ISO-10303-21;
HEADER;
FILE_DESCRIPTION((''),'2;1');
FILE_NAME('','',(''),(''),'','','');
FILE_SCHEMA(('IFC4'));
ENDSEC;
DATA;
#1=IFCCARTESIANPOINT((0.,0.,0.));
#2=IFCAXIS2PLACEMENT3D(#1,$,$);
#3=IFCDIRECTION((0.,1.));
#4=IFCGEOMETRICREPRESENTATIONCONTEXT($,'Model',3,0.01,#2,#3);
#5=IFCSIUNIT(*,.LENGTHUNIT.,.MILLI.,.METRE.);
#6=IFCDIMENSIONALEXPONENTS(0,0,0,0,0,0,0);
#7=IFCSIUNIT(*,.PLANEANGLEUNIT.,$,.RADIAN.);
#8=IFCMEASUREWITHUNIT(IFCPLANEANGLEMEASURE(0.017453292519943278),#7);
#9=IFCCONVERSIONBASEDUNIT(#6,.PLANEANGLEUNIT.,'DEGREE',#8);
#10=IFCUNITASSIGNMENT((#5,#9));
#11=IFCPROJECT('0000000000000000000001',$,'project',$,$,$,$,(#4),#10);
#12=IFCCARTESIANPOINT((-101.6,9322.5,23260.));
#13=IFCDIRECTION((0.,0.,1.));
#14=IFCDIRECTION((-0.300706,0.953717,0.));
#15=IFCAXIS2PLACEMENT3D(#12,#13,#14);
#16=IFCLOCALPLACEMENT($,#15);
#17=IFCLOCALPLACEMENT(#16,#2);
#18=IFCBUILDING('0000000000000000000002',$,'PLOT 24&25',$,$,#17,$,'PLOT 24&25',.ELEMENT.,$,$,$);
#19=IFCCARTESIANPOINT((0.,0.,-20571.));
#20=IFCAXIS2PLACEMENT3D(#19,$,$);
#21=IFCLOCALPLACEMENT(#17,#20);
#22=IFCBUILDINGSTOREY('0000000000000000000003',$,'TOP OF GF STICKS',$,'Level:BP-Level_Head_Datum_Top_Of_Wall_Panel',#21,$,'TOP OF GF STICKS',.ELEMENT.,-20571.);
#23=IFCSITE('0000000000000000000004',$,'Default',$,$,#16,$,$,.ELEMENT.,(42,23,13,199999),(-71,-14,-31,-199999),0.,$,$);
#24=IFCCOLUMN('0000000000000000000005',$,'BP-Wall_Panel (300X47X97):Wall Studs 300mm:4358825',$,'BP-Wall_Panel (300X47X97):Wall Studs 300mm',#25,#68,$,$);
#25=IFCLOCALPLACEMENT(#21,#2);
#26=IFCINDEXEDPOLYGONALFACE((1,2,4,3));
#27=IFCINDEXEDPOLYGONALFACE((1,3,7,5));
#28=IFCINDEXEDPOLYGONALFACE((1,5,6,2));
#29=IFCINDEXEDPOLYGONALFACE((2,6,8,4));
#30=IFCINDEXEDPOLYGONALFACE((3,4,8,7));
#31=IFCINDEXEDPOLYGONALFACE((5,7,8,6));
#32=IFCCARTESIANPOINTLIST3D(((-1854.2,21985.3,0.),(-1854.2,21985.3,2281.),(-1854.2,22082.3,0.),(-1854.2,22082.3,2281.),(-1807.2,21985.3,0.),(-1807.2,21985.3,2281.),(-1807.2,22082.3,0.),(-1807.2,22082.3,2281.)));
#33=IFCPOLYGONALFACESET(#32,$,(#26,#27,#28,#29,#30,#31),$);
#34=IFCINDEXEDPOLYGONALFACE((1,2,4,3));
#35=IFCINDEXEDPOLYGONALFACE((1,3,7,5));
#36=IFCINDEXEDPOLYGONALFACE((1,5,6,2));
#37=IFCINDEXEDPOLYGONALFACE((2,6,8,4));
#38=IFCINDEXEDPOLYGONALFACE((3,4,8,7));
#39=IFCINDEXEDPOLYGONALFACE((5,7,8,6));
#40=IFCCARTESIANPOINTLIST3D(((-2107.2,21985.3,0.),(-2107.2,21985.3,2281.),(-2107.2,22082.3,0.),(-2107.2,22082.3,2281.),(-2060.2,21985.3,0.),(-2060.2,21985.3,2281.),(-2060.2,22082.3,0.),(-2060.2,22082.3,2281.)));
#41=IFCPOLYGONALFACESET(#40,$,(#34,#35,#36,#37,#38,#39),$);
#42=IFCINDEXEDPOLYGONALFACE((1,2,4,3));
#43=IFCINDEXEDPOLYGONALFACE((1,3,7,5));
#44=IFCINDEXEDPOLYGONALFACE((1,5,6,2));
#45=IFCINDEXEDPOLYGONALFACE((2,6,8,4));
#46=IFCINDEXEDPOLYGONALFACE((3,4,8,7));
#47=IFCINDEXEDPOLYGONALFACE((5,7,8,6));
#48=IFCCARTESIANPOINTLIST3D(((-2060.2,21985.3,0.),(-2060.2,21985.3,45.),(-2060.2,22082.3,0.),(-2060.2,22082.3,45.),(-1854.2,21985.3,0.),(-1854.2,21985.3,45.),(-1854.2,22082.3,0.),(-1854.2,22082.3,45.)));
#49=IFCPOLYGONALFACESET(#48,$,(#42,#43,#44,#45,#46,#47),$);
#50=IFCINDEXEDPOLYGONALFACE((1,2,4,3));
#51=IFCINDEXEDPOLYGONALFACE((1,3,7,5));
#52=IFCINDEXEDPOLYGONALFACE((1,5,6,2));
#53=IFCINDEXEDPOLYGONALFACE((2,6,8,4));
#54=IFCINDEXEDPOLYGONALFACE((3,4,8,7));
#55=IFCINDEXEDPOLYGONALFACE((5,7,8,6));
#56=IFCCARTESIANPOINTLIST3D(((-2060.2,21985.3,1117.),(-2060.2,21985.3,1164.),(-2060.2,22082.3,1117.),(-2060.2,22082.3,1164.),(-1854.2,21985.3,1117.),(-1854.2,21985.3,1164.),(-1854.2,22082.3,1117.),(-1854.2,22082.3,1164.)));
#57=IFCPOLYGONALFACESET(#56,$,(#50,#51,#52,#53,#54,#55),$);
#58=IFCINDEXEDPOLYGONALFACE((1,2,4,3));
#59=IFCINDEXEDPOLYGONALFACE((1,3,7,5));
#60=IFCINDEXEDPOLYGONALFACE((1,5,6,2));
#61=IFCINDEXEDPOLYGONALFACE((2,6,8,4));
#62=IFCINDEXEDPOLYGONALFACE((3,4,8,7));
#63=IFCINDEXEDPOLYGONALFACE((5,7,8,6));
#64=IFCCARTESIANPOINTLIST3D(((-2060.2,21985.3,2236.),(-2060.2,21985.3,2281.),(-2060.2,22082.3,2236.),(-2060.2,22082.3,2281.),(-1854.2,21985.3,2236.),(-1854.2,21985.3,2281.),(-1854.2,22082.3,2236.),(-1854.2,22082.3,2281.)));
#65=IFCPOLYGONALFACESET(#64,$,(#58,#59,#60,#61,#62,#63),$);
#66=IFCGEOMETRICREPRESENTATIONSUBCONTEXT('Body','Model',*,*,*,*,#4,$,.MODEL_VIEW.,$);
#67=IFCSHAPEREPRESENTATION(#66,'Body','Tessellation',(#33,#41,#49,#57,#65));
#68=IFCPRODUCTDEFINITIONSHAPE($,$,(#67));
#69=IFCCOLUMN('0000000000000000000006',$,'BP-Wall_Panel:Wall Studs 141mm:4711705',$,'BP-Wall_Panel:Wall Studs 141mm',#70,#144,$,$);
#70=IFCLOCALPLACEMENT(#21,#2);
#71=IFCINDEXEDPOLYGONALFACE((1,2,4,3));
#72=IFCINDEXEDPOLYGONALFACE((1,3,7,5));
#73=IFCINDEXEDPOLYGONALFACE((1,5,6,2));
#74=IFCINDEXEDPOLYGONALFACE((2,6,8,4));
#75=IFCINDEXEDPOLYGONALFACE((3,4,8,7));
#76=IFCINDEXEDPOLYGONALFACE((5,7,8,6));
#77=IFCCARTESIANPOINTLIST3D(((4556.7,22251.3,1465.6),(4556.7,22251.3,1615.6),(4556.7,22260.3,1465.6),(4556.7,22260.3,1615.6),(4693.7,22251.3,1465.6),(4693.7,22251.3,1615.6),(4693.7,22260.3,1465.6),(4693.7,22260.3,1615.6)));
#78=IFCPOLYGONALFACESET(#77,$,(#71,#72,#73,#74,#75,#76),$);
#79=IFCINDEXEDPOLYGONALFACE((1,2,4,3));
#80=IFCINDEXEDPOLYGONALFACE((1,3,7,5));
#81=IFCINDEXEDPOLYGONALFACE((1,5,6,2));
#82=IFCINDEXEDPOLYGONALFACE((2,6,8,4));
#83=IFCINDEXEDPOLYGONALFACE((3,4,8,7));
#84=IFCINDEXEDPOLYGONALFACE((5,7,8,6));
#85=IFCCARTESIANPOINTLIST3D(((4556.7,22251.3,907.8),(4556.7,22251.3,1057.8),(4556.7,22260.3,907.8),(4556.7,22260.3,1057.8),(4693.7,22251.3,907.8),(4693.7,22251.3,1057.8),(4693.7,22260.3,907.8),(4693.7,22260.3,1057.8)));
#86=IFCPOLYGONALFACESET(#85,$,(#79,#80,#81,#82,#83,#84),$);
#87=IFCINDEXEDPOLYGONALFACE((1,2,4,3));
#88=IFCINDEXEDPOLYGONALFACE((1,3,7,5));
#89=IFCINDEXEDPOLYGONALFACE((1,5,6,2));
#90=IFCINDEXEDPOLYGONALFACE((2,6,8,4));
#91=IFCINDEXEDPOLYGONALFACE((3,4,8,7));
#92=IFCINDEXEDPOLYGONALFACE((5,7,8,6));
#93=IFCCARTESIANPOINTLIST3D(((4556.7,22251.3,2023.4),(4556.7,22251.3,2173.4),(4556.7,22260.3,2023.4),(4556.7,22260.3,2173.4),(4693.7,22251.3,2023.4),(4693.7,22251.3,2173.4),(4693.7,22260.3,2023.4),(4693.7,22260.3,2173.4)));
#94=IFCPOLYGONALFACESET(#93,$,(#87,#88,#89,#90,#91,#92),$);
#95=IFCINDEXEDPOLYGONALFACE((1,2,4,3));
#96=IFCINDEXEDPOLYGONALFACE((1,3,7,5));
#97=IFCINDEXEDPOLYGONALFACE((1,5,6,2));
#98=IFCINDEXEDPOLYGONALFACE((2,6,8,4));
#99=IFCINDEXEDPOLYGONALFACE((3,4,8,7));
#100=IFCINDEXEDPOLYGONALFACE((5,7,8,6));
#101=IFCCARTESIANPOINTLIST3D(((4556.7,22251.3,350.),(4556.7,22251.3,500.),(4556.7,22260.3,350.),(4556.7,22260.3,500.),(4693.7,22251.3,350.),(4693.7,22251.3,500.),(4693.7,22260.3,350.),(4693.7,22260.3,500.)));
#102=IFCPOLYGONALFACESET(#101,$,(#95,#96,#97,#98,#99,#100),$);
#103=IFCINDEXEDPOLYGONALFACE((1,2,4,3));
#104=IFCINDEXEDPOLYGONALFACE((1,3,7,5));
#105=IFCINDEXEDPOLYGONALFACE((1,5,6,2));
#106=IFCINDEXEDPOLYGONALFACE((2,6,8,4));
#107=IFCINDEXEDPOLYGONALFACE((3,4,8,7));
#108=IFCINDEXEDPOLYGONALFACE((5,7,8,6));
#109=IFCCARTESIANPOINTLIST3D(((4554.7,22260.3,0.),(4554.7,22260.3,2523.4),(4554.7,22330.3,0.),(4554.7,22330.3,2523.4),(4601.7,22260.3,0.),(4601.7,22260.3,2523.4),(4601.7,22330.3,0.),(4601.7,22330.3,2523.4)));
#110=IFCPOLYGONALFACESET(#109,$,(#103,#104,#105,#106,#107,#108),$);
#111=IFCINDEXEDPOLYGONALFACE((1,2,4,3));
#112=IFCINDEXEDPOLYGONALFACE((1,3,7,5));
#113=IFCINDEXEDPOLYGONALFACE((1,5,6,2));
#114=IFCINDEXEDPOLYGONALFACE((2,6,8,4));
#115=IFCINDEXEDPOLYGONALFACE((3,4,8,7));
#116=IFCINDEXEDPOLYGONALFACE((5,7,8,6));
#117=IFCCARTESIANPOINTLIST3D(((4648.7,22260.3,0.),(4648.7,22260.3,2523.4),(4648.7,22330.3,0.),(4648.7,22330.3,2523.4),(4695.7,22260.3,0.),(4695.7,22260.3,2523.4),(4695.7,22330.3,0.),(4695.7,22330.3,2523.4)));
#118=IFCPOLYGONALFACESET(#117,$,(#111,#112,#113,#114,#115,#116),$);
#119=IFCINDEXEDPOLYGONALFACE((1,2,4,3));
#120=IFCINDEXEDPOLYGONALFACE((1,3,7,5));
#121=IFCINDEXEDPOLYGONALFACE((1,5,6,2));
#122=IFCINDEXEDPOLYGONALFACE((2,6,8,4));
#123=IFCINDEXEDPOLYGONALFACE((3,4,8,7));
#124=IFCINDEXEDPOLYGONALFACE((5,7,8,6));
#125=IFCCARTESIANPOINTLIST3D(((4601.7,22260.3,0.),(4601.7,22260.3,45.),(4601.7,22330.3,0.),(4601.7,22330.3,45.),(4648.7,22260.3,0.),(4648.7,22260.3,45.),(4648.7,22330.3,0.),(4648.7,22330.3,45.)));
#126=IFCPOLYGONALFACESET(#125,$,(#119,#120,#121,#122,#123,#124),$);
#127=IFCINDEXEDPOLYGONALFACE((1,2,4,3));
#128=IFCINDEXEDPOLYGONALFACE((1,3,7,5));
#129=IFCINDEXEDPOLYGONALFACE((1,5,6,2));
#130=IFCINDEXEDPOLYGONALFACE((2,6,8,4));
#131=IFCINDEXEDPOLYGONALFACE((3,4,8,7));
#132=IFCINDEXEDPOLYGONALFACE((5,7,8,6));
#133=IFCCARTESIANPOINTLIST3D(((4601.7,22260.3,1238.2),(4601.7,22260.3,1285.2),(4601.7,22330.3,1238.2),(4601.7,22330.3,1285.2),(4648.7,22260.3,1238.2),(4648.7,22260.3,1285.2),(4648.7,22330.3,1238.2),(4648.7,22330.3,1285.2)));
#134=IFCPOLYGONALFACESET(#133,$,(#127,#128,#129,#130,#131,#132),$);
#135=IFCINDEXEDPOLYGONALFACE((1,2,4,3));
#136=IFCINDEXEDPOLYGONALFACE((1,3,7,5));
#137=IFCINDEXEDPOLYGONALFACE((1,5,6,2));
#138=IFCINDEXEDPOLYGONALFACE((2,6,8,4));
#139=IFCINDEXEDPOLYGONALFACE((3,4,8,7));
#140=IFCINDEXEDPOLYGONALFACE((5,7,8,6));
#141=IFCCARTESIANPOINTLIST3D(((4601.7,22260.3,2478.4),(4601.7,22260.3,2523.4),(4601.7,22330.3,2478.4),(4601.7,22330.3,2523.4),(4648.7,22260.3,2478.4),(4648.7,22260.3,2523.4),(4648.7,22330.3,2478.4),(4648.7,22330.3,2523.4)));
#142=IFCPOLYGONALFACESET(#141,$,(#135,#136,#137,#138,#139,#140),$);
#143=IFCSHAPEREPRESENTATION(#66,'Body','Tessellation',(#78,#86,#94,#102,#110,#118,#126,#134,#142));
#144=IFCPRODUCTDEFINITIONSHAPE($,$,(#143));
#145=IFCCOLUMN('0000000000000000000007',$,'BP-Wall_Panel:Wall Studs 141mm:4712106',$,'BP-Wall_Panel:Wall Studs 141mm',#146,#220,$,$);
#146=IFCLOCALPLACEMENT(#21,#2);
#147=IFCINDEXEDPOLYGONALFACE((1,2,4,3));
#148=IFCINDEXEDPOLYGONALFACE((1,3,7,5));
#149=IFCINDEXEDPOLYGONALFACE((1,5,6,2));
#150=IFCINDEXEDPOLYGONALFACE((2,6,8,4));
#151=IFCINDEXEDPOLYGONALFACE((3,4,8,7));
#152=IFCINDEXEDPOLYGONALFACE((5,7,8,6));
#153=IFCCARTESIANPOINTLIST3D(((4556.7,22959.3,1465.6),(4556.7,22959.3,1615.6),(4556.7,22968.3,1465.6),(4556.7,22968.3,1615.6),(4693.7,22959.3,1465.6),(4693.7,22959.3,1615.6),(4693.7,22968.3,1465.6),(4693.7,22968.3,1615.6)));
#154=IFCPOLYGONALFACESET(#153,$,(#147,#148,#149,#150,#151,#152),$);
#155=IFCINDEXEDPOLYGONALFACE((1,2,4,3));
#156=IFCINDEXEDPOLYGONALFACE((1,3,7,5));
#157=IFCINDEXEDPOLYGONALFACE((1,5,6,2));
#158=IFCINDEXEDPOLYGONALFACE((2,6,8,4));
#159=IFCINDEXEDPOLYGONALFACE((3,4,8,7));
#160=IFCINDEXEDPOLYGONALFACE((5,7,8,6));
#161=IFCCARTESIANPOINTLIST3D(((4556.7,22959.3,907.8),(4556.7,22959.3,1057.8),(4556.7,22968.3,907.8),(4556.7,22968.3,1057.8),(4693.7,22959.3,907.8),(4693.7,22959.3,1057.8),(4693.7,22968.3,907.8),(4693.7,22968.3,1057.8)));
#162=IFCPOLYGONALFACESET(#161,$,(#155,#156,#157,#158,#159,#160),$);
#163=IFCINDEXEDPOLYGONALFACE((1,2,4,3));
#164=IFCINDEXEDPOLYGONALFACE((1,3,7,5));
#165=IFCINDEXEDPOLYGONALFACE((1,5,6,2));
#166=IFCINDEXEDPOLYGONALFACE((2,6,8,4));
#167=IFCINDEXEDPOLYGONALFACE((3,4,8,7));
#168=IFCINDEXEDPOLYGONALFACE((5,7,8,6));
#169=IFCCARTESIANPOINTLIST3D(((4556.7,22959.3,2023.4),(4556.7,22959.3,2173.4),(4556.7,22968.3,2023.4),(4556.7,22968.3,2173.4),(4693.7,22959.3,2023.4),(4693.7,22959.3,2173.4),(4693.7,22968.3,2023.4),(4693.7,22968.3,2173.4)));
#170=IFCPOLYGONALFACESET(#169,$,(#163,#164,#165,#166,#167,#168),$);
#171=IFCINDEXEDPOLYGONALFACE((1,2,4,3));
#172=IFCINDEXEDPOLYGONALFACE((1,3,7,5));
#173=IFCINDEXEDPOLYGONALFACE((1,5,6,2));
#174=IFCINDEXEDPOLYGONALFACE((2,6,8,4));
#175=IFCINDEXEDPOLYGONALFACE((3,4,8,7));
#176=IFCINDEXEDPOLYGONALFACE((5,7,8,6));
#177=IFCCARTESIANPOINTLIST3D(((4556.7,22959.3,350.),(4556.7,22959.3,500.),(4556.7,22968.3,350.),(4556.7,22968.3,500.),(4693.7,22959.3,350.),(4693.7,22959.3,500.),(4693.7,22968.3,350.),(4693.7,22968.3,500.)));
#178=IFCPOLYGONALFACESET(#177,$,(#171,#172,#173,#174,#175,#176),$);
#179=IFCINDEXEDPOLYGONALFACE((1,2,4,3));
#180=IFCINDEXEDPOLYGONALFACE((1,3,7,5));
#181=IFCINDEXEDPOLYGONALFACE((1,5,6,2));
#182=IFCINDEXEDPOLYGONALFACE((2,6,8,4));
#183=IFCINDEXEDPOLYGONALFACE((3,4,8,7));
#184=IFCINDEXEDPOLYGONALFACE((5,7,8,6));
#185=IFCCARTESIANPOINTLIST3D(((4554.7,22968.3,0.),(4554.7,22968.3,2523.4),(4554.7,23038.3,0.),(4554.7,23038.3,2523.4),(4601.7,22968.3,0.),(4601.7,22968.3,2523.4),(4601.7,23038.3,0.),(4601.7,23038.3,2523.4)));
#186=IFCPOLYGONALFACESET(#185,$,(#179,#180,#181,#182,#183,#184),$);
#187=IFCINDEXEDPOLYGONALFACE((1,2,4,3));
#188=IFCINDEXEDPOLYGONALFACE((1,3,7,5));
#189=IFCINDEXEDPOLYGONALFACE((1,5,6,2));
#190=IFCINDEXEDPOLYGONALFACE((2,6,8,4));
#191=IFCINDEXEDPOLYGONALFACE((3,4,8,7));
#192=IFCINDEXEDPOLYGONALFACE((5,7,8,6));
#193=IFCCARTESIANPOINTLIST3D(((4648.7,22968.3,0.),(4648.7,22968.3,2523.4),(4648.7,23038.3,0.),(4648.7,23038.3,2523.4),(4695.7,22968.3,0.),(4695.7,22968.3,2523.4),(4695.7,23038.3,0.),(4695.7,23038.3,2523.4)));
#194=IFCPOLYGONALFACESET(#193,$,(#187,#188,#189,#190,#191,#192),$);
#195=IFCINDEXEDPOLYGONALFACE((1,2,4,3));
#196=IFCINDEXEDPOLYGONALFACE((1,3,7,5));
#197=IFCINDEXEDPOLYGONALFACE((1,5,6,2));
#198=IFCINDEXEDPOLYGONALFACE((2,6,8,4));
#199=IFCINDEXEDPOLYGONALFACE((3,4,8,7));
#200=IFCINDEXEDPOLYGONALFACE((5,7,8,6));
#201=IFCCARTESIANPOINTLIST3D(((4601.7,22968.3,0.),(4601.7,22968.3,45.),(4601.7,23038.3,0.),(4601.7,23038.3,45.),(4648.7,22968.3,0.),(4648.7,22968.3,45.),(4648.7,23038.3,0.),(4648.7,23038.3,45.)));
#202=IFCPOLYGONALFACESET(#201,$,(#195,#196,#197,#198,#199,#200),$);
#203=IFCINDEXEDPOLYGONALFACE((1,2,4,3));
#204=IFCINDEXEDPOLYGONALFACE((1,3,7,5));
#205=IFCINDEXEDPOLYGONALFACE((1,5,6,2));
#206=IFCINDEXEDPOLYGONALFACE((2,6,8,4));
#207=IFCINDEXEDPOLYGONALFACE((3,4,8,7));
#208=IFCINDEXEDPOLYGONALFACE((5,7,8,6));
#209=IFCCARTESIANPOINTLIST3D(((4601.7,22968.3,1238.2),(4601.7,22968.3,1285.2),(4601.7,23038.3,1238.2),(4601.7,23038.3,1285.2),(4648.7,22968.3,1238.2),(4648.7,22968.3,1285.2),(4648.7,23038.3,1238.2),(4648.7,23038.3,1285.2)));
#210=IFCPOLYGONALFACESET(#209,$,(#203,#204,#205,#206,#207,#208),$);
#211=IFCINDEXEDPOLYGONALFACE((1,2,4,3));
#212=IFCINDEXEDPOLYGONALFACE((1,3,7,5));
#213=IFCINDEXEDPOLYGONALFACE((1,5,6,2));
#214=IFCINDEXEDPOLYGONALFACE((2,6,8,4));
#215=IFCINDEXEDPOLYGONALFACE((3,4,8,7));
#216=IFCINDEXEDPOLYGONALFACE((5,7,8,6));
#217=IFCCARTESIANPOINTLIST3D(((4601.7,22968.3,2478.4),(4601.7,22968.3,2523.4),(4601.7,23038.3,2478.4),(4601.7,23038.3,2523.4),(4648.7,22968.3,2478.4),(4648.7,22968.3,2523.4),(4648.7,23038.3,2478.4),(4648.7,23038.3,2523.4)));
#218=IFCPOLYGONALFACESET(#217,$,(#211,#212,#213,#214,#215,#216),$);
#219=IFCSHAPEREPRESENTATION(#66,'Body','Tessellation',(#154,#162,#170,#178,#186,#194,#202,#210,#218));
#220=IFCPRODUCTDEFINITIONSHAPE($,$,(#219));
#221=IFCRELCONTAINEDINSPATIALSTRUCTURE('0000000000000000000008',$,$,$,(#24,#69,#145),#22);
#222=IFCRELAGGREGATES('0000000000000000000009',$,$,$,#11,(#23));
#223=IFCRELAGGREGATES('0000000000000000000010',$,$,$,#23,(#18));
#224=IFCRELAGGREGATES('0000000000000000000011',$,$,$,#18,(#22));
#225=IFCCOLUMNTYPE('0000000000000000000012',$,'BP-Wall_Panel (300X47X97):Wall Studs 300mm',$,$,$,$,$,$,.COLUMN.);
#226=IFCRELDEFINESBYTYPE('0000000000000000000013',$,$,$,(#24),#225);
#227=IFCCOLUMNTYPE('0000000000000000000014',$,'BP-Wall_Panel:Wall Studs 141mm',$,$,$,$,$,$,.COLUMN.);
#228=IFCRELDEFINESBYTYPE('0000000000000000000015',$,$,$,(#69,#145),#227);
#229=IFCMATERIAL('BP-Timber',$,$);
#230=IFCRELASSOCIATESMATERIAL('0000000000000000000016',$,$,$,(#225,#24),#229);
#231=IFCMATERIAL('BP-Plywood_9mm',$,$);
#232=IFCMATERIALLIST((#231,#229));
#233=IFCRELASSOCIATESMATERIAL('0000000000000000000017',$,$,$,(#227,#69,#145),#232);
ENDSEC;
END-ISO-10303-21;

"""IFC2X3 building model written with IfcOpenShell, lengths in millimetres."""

from ifc_helpers import new_model, entity, si_unit, converted_unit, direction, frame, frame_2d, origin, origin_2d_with_axis, place, context, subcontext, project, spatial, rectangle, extrude, source, transform, mapped, material, material_list, type_object, type_shapes, element, save


model = new_model("IFC2X3")

# Units and contexts
model_context = context("Model", 3, precision=0.01, world=origin(), true_north=direction((0.0, 1.0)))
body_context = subcontext(model_context, "Body", "Model", "MODEL_VIEW")
ifc_project = project(units=[si_unit("LENGTHUNIT", "METRE", prefix="MILLI"), converted_unit("PLANEANGLEUNIT", "DEGREE", entity("IfcPlaneAngleMeasure", 0.017453292519943278), si_unit("PLANEANGLEUNIT", "RADIAN"), dimensions=[0, 0, 0, 0, 0, 0, 0])], contexts=[model_context])

# Site, building, storey
site_placement = place(None, frame((-101.6, 9322.5, 23260.0), z_axis=(0.0, 0.0, 1.0), x_axis=(-0.300706, 0.953717, 0.0)))
site = spatial("IfcSite", under=ifc_project, at=site_placement, Name="Default", CompositionType="ELEMENT", RefLatitude=(42, 23, 13, 199999), RefLongitude=(-71, -14, -31, -199999), RefElevation=0.0)
building_placement = place(site_placement, origin())
building = spatial("IfcBuilding", under=site, at=building_placement, Name="PLOT 24&25", LongName="PLOT 24&25", CompositionType="ELEMENT")
storey_placement = place(building_placement, frame((0.0, 0.0, -20571.0)))
storey = spatial("IfcBuildingStorey", under=building, at=storey_placement, Name="TOP OF GF STICKS", ObjectType="Level:BP-Level_Head_Datum_Top_Of_Wall_Panel", LongName="TOP OF GF STICKS", CompositionType="ELEMENT", Elevation=-20571.0)

# Columns
ifc_material_1 = material(Name="BP-Plywood_9mm")
ifc_material_2 = material(Name="BP-Timber")
ifc_material_list = material_list([ifc_material_1, ifc_material_2])
column_type_1 = type_object("IfcColumnType", Name="BP-Wall_Panel (300X47X97):Wall Studs 300mm", PredefinedType="COLUMN", material=ifc_material_2)
shared_shape_1 = source(origin(), body_context, "Body", "SweptSolid", [
    extrude(rectangle(XDim=97.0, YDim=47.0, at=origin_2d_with_axis()), frame((0.0, -126.5, -20571.0), z_axis=(0.0, 0.0, 1.0), x_axis=(-1.0, 0.0, 0.0)), (0.0, 0.0, 1.0), 2281.0),
    extrude(rectangle(XDim=97.0, YDim=47.0, at=frame_2d((0.0, 0.0), x_axis=(1.0, 0.0))), frame((0.0, 126.5, -20571.0), z_axis=(0.0, 0.0, 1.0), x_axis=(-1.0, 0.0, 0.0)), (0.0, 0.0, 1.0), 2281.0),
    extrude(rectangle(XDim=206.0, YDim=97.0, at=origin_2d_with_axis()), frame((0.0, 0.0, -20571.0), z_axis=(0.0, 0.0, 1.0), x_axis=(0.0, -1.0, 0.0)), (0.0, 0.0, 1.0), 45.0),
    extrude(rectangle(XDim=206.0, YDim=97.0, at=origin_2d_with_axis()), frame((0.0, 0.0, -19454.0), z_axis=(0.0, 0.0, 1.0), x_axis=(0.0, -1.0, 0.0)), (0.0, 0.0, 1.0), 47.0),
    extrude(rectangle(XDim=206.0, YDim=97.0, at=origin_2d_with_axis()), frame((0.0, 0.0, -18335.0), z_axis=(0.0, 0.0, 1.0), x_axis=(0.0, -1.0, 0.0)), (0.0, 0.0, 1.0), 45.0),
])
type_shapes(column_type_1, [shared_shape_1])
for number, where, z_axis, x_axis, name in (
    (1, (-1957.2, 22033.8, 20571.0), (0.0, 0.0, 1.0), (0.0, 1.0, 0.0), "BP-Wall_Panel (300X47X97):Wall Studs 300mm:4358825"),
):
    element("IfcColumn", number, at=place(storey_placement, frame(where, z_axis=z_axis, x_axis=x_axis)), inside=storey, type_object=column_type_1, material=ifc_material_2, Name=name, ObjectType="BP-Wall_Panel (300X47X97):Wall Studs 300mm", context=body_context, shape_type="MappedRepresentation", body=[
        mapped(shared_shape_1, transform((0.0, 0.0, 0.0), scale=1.0)),
    ])
column_type_2 = type_object("IfcColumnType", Name="BP-Wall_Panel:Wall Studs 141mm", PredefinedType="COLUMN", material=ifc_material_list)
shared_shape_2 = source(origin(), body_context, "Body", "SweptSolid", [
    extrude(rectangle(XDim=137.0, YDim=9.0, at=origin_2d_with_axis()), frame((-39.5, 0.0, -19105.4), z_axis=(0.0, 0.0, 1.0), x_axis=(0.0, 1.0, 0.0)), (0.0, 0.0, 1.0), 150.0),
    extrude(rectangle(XDim=137.0, YDim=9.0, at=origin_2d_with_axis()), frame((-39.5, 0.0, -19663.2), z_axis=(0.0, 0.0, 1.0), x_axis=(0.0, 1.0, 0.0)), (0.0, 0.0, 1.0), 150.0),
    extrude(rectangle(XDim=137.0, YDim=9.0, at=origin_2d_with_axis()), frame((-39.5, 0.0, -18547.6), z_axis=(0.0, 0.0, 1.0), x_axis=(0.0, 1.0, 0.0)), (0.0, 0.0, 1.0), 150.0),
    extrude(rectangle(XDim=137.0, YDim=9.0, at=origin_2d_with_axis()), frame((-39.5, 0.0, -20221.0), z_axis=(0.0, 0.0, 1.0), x_axis=(0.0, 1.0, 0.0)), (0.0, 0.0, 1.0), 150.0),
    extrude(rectangle(XDim=47.0, YDim=70.0, at=origin_2d_with_axis()), frame((0.0, 47.0, -20571.0), z_axis=(0.0, 0.0, 1.0), x_axis=(0.0, 1.0, 0.0)), (0.0, 0.0, 1.0), 2523.4),
    extrude(rectangle(XDim=47.0, YDim=70.0, at=origin_2d_with_axis()), frame((0.0, -47.0, -20571.0), z_axis=(0.0, 0.0, 1.0), x_axis=(0.0, 1.0, 0.0)), (0.0, 0.0, 1.0), 2523.4),
    extrude(rectangle(XDim=70.0, YDim=47.0, at=origin_2d_with_axis()), frame((0.0, 0.0, -20571.0)), (0.0, 0.0, 1.0), 45.0),
    extrude(rectangle(XDim=70.0, YDim=47.0, at=origin_2d_with_axis()), frame((0.0, 0.0, -19332.8)), (0.0, 0.0, 1.0), 47.0),
    extrude(rectangle(XDim=70.0, YDim=47.0, at=origin_2d_with_axis()), frame((0.0, 0.0, -18092.6)), (0.0, 0.0, 1.0), 45.0),
])
type_shapes(column_type_2, [shared_shape_2])
for number, where, z_axis, x_axis, name in (
    (2, (4625.2, 22295.3, 20571.0), (0.0, 0.0, 1.0), (0.0, 1.0, 0.0), "BP-Wall_Panel:Wall Studs 141mm:4711705"),
    (3, (4625.2, 23003.3, 20571.0), (0.0, 0.0, 1.0), (0.0, 1.0, 0.0), "BP-Wall_Panel:Wall Studs 141mm:4712106"),
):
    element("IfcColumn", number, at=place(storey_placement, frame(where, z_axis=z_axis, x_axis=x_axis)), inside=storey, type_object=column_type_2, material=ifc_material_list, Name=name, ObjectType="BP-Wall_Panel:Wall Studs 141mm", context=body_context, shape_type="MappedRepresentation", body=[
        mapped(shared_shape_2, transform((0.0, 0.0, 0.0), scale=1.0)),
    ])

save(model, "model.ifc")
